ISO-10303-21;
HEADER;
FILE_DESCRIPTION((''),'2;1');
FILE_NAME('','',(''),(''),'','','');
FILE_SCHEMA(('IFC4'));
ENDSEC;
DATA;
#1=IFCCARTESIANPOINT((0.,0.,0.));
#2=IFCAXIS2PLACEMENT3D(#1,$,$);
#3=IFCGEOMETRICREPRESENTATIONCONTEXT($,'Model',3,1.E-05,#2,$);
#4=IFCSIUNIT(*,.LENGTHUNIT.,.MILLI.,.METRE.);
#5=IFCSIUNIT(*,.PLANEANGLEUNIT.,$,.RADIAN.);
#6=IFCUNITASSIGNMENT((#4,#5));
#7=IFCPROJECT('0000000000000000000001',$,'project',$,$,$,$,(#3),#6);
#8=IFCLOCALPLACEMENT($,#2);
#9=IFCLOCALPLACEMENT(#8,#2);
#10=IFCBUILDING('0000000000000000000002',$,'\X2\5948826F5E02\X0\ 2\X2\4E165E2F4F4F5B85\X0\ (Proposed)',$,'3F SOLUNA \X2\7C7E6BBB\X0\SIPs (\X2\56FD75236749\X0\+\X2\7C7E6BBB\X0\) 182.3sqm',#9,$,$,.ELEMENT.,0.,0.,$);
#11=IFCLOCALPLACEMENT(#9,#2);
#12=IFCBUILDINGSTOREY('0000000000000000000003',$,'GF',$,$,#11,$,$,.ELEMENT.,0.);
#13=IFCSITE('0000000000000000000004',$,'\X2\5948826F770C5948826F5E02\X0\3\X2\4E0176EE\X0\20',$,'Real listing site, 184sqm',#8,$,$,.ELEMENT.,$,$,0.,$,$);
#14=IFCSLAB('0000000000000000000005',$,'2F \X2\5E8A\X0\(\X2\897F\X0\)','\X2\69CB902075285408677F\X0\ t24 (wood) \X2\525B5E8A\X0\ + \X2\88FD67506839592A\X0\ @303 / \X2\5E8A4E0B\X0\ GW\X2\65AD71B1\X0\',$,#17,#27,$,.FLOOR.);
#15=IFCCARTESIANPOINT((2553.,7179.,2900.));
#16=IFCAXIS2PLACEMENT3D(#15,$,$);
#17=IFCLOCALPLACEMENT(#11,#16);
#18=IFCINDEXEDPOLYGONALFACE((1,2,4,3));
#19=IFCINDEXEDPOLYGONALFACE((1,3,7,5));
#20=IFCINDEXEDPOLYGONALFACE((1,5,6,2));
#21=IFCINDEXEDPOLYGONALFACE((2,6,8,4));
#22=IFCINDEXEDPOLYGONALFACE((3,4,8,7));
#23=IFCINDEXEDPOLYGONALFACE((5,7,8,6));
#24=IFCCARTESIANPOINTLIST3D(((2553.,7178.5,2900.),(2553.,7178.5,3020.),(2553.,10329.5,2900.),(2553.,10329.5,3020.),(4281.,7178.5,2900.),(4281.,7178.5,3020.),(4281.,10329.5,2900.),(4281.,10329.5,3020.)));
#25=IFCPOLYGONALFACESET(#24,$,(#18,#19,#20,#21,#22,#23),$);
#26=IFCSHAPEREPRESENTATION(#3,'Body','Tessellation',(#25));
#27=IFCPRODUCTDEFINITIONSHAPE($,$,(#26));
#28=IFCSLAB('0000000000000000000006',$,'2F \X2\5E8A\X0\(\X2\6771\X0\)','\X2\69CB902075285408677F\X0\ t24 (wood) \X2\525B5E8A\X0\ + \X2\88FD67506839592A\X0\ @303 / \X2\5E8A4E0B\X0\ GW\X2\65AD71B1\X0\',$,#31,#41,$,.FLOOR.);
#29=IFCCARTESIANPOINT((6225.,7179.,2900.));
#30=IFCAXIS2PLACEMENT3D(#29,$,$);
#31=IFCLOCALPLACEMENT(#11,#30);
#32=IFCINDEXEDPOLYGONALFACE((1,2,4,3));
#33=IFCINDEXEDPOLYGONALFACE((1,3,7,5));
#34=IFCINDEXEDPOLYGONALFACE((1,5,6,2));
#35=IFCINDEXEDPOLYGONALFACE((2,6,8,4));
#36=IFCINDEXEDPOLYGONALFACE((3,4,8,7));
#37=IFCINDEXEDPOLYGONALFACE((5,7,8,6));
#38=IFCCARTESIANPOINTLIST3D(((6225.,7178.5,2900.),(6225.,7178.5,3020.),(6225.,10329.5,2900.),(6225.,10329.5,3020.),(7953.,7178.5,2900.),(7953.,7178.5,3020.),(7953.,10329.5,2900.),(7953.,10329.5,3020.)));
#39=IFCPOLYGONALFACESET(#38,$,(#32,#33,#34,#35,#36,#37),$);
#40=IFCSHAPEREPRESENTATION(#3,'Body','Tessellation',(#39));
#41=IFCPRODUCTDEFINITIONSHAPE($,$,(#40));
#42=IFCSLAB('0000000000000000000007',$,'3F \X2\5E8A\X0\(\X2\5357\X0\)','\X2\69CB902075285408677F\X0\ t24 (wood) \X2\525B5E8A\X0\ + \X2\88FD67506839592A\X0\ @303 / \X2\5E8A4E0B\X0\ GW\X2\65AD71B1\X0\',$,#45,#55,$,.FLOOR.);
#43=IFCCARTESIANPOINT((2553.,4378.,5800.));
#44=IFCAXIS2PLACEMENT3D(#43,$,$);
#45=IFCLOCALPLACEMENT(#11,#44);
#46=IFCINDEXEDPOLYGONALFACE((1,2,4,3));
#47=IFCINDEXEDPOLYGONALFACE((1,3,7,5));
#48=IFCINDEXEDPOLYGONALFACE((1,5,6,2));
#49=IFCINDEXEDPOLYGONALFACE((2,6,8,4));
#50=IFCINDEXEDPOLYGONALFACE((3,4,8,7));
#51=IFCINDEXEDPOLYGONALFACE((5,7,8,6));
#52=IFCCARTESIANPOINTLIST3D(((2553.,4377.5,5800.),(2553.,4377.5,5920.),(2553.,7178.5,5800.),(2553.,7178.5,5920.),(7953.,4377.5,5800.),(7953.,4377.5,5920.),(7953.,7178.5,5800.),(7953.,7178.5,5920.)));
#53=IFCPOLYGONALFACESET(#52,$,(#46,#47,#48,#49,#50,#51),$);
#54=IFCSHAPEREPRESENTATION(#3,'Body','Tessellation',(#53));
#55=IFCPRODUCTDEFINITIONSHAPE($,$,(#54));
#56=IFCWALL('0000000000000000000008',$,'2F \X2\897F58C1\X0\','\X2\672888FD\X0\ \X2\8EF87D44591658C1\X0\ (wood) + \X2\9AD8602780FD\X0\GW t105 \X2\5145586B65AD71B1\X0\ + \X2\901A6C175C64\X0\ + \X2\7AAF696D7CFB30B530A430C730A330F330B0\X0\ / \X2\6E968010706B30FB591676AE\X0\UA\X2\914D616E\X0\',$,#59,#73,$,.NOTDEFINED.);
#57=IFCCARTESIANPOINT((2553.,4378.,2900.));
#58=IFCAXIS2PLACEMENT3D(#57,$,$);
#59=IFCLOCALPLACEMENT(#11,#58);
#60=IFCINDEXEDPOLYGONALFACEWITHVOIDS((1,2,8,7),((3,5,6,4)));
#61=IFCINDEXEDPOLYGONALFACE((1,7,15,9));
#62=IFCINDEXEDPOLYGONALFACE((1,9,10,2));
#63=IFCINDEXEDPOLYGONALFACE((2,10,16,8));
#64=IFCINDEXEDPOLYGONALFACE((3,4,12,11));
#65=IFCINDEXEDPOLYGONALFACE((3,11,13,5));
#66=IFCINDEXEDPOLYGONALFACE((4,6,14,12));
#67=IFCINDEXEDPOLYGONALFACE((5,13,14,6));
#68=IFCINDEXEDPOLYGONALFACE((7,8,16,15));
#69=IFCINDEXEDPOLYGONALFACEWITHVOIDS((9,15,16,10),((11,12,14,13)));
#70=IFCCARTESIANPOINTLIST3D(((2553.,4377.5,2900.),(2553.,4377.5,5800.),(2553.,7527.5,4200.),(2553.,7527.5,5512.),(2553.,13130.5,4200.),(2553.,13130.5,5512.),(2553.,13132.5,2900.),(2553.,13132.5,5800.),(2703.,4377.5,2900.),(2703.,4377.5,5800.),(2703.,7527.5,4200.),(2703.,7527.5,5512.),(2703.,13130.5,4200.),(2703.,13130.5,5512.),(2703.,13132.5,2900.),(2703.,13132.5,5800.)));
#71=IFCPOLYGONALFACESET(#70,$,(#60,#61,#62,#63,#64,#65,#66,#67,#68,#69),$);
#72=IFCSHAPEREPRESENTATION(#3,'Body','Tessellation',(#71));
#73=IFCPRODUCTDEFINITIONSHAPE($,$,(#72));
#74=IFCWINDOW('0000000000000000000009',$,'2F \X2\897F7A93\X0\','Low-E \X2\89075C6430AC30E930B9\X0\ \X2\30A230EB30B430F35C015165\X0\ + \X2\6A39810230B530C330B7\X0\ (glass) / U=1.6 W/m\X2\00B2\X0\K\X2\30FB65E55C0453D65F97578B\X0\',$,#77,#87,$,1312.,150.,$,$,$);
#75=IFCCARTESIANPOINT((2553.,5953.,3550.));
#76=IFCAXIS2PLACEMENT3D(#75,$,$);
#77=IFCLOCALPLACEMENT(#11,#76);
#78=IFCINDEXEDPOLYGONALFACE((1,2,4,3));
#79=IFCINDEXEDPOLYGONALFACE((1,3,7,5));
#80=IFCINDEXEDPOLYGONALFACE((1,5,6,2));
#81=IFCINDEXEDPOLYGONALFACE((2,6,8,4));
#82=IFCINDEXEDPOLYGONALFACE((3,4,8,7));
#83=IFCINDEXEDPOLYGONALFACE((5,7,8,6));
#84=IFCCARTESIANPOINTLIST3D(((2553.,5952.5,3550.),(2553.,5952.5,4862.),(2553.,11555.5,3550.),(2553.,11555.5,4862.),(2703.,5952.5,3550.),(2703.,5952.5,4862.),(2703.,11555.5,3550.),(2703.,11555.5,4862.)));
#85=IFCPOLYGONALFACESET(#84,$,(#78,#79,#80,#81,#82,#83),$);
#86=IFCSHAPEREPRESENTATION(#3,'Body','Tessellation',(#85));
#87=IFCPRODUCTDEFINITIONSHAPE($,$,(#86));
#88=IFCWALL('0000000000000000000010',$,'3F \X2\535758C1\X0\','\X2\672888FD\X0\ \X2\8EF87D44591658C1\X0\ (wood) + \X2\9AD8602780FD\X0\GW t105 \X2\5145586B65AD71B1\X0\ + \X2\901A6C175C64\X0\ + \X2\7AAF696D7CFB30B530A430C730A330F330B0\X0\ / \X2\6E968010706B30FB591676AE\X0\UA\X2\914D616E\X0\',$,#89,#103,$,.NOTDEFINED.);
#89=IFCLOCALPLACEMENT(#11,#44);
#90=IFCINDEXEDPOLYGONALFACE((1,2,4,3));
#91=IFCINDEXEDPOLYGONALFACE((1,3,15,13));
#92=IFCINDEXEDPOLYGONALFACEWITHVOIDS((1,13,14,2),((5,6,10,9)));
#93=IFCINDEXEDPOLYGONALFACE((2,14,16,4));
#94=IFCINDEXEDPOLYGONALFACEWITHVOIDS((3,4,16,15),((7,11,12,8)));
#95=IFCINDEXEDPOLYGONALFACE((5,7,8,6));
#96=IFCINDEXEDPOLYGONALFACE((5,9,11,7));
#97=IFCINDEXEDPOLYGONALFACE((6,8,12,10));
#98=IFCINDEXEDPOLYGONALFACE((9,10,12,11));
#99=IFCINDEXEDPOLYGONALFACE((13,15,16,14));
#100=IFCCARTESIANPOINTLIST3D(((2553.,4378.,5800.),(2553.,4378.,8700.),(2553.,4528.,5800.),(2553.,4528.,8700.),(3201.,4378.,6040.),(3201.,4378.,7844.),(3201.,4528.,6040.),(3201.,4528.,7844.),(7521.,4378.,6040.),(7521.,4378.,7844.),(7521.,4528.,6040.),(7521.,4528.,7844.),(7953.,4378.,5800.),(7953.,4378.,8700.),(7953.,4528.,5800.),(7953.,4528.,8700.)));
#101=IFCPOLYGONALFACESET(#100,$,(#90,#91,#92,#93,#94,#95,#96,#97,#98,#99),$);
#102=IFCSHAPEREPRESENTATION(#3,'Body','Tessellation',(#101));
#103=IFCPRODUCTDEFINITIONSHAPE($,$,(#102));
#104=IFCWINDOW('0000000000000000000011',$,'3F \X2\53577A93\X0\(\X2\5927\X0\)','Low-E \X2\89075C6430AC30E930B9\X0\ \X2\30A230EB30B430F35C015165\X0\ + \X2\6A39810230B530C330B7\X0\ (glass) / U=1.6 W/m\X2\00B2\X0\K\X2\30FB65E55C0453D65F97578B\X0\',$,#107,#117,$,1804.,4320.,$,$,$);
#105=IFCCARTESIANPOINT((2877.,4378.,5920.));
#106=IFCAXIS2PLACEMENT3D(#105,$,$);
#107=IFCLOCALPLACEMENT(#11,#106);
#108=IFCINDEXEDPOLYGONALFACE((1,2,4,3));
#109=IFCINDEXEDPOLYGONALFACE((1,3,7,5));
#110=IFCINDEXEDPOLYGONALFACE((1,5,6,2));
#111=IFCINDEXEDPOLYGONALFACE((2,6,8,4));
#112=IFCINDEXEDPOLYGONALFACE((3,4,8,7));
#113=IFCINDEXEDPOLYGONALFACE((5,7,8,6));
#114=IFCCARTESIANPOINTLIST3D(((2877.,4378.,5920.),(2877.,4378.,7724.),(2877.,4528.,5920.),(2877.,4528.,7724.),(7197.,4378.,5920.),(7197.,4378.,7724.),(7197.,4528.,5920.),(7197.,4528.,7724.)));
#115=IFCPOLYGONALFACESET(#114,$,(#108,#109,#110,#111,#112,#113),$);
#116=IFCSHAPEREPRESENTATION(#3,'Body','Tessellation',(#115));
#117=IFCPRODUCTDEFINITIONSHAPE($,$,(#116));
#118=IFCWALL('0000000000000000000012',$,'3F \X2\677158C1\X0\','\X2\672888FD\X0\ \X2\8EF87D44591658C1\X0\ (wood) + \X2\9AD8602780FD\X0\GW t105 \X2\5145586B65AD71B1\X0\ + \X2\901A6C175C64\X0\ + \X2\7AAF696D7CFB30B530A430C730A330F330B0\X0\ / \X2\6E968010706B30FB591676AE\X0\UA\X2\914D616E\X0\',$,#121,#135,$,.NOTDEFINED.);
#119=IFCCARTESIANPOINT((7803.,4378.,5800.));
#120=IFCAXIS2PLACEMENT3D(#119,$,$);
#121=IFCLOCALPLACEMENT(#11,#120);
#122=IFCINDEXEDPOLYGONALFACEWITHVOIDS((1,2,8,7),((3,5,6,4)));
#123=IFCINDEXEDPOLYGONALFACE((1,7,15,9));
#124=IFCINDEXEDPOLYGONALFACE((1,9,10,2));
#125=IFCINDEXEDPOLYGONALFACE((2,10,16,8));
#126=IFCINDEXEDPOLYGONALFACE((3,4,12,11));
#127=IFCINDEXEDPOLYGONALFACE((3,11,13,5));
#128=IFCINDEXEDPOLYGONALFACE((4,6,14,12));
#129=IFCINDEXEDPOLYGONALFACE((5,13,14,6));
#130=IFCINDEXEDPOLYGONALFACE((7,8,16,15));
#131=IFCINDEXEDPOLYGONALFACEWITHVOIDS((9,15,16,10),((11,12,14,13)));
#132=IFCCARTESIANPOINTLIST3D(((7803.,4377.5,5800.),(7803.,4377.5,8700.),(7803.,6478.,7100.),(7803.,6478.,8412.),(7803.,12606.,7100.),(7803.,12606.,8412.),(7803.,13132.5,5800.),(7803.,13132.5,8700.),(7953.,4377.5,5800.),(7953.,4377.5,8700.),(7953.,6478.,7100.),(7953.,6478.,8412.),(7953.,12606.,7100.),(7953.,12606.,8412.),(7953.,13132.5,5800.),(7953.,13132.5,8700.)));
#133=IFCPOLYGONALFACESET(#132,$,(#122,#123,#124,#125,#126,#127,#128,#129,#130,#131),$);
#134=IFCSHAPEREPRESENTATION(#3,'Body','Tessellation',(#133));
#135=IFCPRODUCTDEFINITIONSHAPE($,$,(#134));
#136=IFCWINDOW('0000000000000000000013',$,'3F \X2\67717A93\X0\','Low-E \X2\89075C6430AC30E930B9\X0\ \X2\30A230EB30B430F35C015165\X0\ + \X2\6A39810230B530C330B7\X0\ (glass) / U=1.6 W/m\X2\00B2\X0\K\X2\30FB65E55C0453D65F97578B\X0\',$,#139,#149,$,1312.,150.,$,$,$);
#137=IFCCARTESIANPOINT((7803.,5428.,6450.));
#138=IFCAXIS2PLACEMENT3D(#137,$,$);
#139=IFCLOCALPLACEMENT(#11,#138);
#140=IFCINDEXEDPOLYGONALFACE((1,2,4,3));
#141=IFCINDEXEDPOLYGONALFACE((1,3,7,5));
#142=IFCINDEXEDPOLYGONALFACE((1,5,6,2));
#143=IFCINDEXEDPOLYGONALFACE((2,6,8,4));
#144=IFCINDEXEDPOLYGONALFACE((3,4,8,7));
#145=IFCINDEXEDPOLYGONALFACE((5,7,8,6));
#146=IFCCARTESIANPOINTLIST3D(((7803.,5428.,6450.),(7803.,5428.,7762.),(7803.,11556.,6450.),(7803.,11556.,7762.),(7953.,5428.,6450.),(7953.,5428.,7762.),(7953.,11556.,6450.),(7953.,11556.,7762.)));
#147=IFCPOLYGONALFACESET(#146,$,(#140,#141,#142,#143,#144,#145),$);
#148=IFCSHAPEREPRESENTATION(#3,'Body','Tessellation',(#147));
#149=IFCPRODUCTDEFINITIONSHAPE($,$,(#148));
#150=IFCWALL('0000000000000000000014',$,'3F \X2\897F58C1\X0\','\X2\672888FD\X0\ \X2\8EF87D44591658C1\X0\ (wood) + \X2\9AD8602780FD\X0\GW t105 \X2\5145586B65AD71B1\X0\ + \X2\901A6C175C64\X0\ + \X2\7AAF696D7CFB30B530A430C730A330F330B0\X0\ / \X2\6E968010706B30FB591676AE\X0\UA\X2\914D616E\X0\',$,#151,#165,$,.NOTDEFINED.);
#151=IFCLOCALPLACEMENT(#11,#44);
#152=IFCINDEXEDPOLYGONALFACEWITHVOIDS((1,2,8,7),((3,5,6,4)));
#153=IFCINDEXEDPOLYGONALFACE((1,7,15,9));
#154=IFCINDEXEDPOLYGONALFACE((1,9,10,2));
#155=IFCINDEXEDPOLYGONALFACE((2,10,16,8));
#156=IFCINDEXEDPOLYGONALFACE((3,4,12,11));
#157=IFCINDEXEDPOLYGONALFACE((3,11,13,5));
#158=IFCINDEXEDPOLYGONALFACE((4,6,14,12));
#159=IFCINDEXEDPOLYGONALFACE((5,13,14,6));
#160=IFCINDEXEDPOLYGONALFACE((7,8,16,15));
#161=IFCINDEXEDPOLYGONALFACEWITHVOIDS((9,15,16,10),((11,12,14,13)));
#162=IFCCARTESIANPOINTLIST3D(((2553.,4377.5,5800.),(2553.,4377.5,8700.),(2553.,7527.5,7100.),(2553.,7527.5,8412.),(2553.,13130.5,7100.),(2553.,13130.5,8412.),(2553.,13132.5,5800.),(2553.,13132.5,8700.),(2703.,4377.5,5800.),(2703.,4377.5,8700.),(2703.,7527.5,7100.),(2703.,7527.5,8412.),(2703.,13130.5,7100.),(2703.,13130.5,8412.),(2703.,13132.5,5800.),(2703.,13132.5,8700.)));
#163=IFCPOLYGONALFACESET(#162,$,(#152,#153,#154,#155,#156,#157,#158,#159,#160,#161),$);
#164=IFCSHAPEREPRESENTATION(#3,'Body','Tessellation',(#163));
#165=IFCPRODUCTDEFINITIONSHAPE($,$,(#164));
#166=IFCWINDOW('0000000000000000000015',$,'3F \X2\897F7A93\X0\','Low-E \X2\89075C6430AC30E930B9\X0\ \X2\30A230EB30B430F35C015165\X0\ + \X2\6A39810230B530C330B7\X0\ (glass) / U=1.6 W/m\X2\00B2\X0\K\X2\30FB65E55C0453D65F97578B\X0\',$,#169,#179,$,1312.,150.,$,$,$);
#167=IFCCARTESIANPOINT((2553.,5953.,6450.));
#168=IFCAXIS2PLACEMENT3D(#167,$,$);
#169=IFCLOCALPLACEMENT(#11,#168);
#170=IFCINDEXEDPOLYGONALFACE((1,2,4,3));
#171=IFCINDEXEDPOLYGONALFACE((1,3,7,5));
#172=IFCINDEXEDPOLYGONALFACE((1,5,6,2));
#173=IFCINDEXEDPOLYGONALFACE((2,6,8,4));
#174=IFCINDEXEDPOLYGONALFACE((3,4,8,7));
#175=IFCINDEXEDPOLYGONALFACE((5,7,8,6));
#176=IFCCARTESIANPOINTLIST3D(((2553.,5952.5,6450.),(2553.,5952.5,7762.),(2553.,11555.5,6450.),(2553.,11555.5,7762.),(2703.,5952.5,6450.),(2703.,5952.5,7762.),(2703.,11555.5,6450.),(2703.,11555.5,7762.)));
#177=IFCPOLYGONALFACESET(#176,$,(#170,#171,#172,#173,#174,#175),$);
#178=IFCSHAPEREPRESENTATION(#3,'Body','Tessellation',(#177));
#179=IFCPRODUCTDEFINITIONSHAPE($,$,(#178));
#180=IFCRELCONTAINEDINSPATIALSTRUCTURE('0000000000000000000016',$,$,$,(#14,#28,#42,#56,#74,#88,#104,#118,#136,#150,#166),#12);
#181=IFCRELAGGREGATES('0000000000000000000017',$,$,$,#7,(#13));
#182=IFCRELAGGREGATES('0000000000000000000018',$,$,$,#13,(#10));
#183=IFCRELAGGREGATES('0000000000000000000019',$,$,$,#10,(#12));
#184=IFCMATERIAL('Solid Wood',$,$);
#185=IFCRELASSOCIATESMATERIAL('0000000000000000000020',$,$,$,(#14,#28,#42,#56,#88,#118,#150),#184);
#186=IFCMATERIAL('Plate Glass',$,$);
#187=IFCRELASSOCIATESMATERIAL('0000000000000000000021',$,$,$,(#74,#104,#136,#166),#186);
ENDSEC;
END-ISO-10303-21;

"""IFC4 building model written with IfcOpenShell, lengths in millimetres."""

from ifc_helpers import new_model, si_unit, frame, frame_2d, origin, place, context, project, spatial, rectangle, extrude, material, element, fill, save


model = new_model("IFC4")

# Units and contexts
model_context = context("Model", 3, precision=1e-05, world=origin())
ifc_project = project(units=[si_unit("LENGTHUNIT", "METRE", prefix="MILLI"), si_unit("PLANEANGLEUNIT", "RADIAN")], contexts=[model_context])

# Site, building, storey
site_placement = place(None, origin())
site = spatial("IfcSite", under=ifc_project, at=site_placement, Name="奈良県奈良市3丁目20", ObjectType="Real listing site, 184sqm", CompositionType="ELEMENT", RefElevation=0.0)
building_placement = place(site_placement, origin())
building = spatial("IfcBuilding", under=site, at=building_placement, Name="奈良市 2世帯住宅 (Proposed)", ObjectType="3F SOLUNA 籾殻SIPs (国産杉+籾殻) 182.3sqm", CompositionType="ELEMENT", ElevationOfRefHeight=0.0, ElevationOfTerrain=0.0)
storey_placement = place(building_placement, origin())
storey = spatial("IfcBuildingStorey", under=building, at=storey_placement, Name="GF", CompositionType="ELEMENT", Elevation=0.0)

# Slabs
ifc_material_1 = material(Name="Solid Wood")
slab_1_placement = place(storey_placement, frame((2553.0, 7179.0, 2900.0)))
element("IfcSlab", 1, at=slab_1_placement, inside=storey, material=ifc_material_1, Name="2F 床(西)", Description="構造用合板 t24 (wood) 剛床 + 製材根太 @303 / 床下 GW断熱", PredefinedType="FLOOR", context=model_context, shape_type="SweptSolid", body=[
    extrude(rectangle(XDim=1728.0, YDim=3151.0, at=frame_2d((864.0, 1575.0))), frame((2553.0, 7179.0, 2900.0)), (0.0, 0.0, 1.0), 120.0),
])
slab_2_placement = place(storey_placement, frame((6225.0, 7179.0, 2900.0)))
element("IfcSlab", 2, at=slab_2_placement, inside=storey, material=ifc_material_1, Name="2F 床(東)", Description="構造用合板 t24 (wood) 剛床 + 製材根太 @303 / 床下 GW断熱", PredefinedType="FLOOR", context=model_context, shape_type="SweptSolid", body=[
    extrude(rectangle(XDim=1728.0, YDim=3151.0, at=frame_2d((864.0, 1575.0))), frame((6225.0, 7179.0, 2900.0)), (0.0, 0.0, 1.0), 120.0),
])
slab_3_placement = place(storey_placement, frame((2553.0, 4378.0, 5800.0)))
element("IfcSlab", 3, at=slab_3_placement, inside=storey, material=ifc_material_1, Name="3F 床(南)", Description="構造用合板 t24 (wood) 剛床 + 製材根太 @303 / 床下 GW断熱", PredefinedType="FLOOR", context=model_context, shape_type="SweptSolid", body=[
    extrude(rectangle(XDim=5400.0, YDim=2801.0, at=frame_2d((2700.0, 1400.0))), frame((2553.0, 4378.0, 5800.0)), (0.0, 0.0, 1.0), 120.0),
])

# Walls, openings, windows
wall_1_placement = place(storey_placement, frame((2553.0, 4378.0, 2900.0)))
wall_1 = element("IfcWall", 4, at=wall_1_placement, inside=storey, material=ifc_material_1, Name="2F 西壁", Description="木製 軸組外壁 (wood) + 高性能GW t105 充填断熱 + 通気層 + 窯業系サイディング / 準耐火・外皮UA配慮", PredefinedType="NOTDEFINED", context=model_context, shape_type="SweptSolid", body=[
    extrude(rectangle(XDim=150.0, YDim=8755.0, at=frame_2d((75.0, 4377.0))), frame((2553.0, 4378.0, 2900.0)), (0.0, 0.0, 1.0), 2900.0),
])
opening_1_placement = place(storey_placement, frame((2553.0, 5953.0, 3550.0)))
opening_1 = element("IfcOpeningElement", 5, at=opening_1_placement, cuts=wall_1, PredefinedType="NOTDEFINED", context=model_context, shape_type="SweptSolid", body=[
    extrude(rectangle(XDim=150.0, YDim=5603.0, at=frame_2d((75.0, 2801.0))), frame((2553.0, 5953.0, 3550.0)), (0.0, 0.0, 1.0), 1312.0),
])
ifc_material_2 = material(Name="Plate Glass")
window_1_placement = place(storey_placement, frame((2553.0, 5953.0, 3550.0)))
window_1 = element("IfcWindow", 6, at=window_1_placement, inside=storey, material=ifc_material_2, Name="2F 西窓", Description="Low-E 複層ガラス アルゴン封入 + 樹脂サッシ (glass) / U=1.6 W/m²K・日射取得型", OverallHeight=1312.0, OverallWidth=150.0, context=model_context, shape_type="SweptSolid", body=[
    extrude(rectangle(XDim=150.0, YDim=5603.0, at=frame_2d((75.0, 2801.0))), frame((2553.0, 5953.0, 3550.0)), (0.0, 0.0, 1.0), 1312.0),
])
fill(opening_1, window_1)
wall_2_placement = place(storey_placement, frame((2553.0, 4378.0, 5800.0)))
wall_2 = element("IfcWall", 7, at=wall_2_placement, inside=storey, material=ifc_material_1, Name="3F 南壁", Description="木製 軸組外壁 (wood) + 高性能GW t105 充填断熱 + 通気層 + 窯業系サイディング / 準耐火・外皮UA配慮", PredefinedType="NOTDEFINED", context=model_context, shape_type="SweptSolid", body=[
    extrude(rectangle(XDim=5400.0, YDim=150.0, at=frame_2d((2700.0, 75.0))), frame((2553.0, 4378.0, 5800.0)), (0.0, 0.0, 1.0), 2900.0),
])
opening_2_placement = place(storey_placement, frame((2877.0, 4378.0, 5920.0)))
opening_2 = element("IfcOpeningElement", 8, at=opening_2_placement, cuts=wall_2, PredefinedType="NOTDEFINED", context=model_context, shape_type="SweptSolid", body=[
    extrude(rectangle(XDim=4320.0, YDim=150.0, at=frame_2d((2160.0, 75.0))), frame((2877.0, 4378.0, 5920.0)), (0.0, 0.0, 1.0), 1804.0),
])
window_2_placement = place(storey_placement, frame((2877.0, 4378.0, 5920.0)))
window_2 = element("IfcWindow", 9, at=window_2_placement, inside=storey, material=ifc_material_2, Name="3F 南窓(大)", Description="Low-E 複層ガラス アルゴン封入 + 樹脂サッシ (glass) / U=1.6 W/m²K・日射取得型", OverallHeight=1804.0, OverallWidth=4320.0, context=model_context, shape_type="SweptSolid", body=[
    extrude(rectangle(XDim=4320.0, YDim=150.0, at=frame_2d((2160.0, 75.0))), frame((2877.0, 4378.0, 5920.0)), (0.0, 0.0, 1.0), 1804.0),
])
fill(opening_2, window_2)
wall_3_placement = place(storey_placement, frame((7803.0, 4378.0, 5800.0)))
wall_3 = element("IfcWall", 10, at=wall_3_placement, inside=storey, material=ifc_material_1, Name="3F 東壁", Description="木製 軸組外壁 (wood) + 高性能GW t105 充填断熱 + 通気層 + 窯業系サイディング / 準耐火・外皮UA配慮", PredefinedType="NOTDEFINED", context=model_context, shape_type="SweptSolid", body=[
    extrude(rectangle(XDim=150.0, YDim=8755.0, at=frame_2d((75.0, 4377.0))), frame((7803.0, 4378.0, 5800.0)), (0.0, 0.0, 1.0), 2900.0),
])
opening_3_placement = place(storey_placement, frame((7803.0, 5428.0, 6450.0)))
opening_3 = element("IfcOpeningElement", 11, at=opening_3_placement, cuts=wall_3, PredefinedType="NOTDEFINED", context=model_context, shape_type="SweptSolid", body=[
    extrude(rectangle(XDim=150.0, YDim=6128.0, at=frame_2d((75.0, 3064.0))), frame((7803.0, 5428.0, 6450.0)), (0.0, 0.0, 1.0), 1312.0),
])
window_3_placement = place(storey_placement, frame((7803.0, 5428.0, 6450.0)))
window_3 = element("IfcWindow", 12, at=window_3_placement, inside=storey, material=ifc_material_2, Name="3F 東窓", Description="Low-E 複層ガラス アルゴン封入 + 樹脂サッシ (glass) / U=1.6 W/m²K・日射取得型", OverallHeight=1312.0, OverallWidth=150.0, context=model_context, shape_type="SweptSolid", body=[
    extrude(rectangle(XDim=150.0, YDim=6128.0, at=frame_2d((75.0, 3064.0))), frame((7803.0, 5428.0, 6450.0)), (0.0, 0.0, 1.0), 1312.0),
])
fill(opening_3, window_3)
wall_4_placement = place(storey_placement, frame((2553.0, 4378.0, 5800.0)))
wall_4 = element("IfcWall", 13, at=wall_4_placement, inside=storey, material=ifc_material_1, Name="3F 西壁", Description="木製 軸組外壁 (wood) + 高性能GW t105 充填断熱 + 通気層 + 窯業系サイディング / 準耐火・外皮UA配慮", PredefinedType="NOTDEFINED", context=model_context, shape_type="SweptSolid", body=[
    extrude(rectangle(XDim=150.0, YDim=8755.0, at=frame_2d((75.0, 4377.0))), frame((2553.0, 4378.0, 5800.0)), (0.0, 0.0, 1.0), 2900.0),
])
opening_4_placement = place(storey_placement, frame((2553.0, 5953.0, 6450.0)))
opening_4 = element("IfcOpeningElement", 14, at=opening_4_placement, cuts=wall_4, PredefinedType="NOTDEFINED", context=model_context, shape_type="SweptSolid", body=[
    extrude(rectangle(XDim=150.0, YDim=5603.0, at=frame_2d((75.0, 2801.0))), frame((2553.0, 5953.0, 6450.0)), (0.0, 0.0, 1.0), 1312.0),
])
window_4_placement = place(storey_placement, frame((2553.0, 5953.0, 6450.0)))
window_4 = element("IfcWindow", 15, at=window_4_placement, inside=storey, material=ifc_material_2, Name="3F 西窓", Description="Low-E 複層ガラス アルゴン封入 + 樹脂サッシ (glass) / U=1.6 W/m²K・日射取得型", OverallHeight=1312.0, OverallWidth=150.0, context=model_context, shape_type="SweptSolid", body=[
    extrude(rectangle(XDim=150.0, YDim=5603.0, at=frame_2d((75.0, 2801.0))), frame((2553.0, 5953.0, 6450.0)), (0.0, 0.0, 1.0), 1312.0),
])
fill(opening_4, window_4)

save(model, "model.ifc")
